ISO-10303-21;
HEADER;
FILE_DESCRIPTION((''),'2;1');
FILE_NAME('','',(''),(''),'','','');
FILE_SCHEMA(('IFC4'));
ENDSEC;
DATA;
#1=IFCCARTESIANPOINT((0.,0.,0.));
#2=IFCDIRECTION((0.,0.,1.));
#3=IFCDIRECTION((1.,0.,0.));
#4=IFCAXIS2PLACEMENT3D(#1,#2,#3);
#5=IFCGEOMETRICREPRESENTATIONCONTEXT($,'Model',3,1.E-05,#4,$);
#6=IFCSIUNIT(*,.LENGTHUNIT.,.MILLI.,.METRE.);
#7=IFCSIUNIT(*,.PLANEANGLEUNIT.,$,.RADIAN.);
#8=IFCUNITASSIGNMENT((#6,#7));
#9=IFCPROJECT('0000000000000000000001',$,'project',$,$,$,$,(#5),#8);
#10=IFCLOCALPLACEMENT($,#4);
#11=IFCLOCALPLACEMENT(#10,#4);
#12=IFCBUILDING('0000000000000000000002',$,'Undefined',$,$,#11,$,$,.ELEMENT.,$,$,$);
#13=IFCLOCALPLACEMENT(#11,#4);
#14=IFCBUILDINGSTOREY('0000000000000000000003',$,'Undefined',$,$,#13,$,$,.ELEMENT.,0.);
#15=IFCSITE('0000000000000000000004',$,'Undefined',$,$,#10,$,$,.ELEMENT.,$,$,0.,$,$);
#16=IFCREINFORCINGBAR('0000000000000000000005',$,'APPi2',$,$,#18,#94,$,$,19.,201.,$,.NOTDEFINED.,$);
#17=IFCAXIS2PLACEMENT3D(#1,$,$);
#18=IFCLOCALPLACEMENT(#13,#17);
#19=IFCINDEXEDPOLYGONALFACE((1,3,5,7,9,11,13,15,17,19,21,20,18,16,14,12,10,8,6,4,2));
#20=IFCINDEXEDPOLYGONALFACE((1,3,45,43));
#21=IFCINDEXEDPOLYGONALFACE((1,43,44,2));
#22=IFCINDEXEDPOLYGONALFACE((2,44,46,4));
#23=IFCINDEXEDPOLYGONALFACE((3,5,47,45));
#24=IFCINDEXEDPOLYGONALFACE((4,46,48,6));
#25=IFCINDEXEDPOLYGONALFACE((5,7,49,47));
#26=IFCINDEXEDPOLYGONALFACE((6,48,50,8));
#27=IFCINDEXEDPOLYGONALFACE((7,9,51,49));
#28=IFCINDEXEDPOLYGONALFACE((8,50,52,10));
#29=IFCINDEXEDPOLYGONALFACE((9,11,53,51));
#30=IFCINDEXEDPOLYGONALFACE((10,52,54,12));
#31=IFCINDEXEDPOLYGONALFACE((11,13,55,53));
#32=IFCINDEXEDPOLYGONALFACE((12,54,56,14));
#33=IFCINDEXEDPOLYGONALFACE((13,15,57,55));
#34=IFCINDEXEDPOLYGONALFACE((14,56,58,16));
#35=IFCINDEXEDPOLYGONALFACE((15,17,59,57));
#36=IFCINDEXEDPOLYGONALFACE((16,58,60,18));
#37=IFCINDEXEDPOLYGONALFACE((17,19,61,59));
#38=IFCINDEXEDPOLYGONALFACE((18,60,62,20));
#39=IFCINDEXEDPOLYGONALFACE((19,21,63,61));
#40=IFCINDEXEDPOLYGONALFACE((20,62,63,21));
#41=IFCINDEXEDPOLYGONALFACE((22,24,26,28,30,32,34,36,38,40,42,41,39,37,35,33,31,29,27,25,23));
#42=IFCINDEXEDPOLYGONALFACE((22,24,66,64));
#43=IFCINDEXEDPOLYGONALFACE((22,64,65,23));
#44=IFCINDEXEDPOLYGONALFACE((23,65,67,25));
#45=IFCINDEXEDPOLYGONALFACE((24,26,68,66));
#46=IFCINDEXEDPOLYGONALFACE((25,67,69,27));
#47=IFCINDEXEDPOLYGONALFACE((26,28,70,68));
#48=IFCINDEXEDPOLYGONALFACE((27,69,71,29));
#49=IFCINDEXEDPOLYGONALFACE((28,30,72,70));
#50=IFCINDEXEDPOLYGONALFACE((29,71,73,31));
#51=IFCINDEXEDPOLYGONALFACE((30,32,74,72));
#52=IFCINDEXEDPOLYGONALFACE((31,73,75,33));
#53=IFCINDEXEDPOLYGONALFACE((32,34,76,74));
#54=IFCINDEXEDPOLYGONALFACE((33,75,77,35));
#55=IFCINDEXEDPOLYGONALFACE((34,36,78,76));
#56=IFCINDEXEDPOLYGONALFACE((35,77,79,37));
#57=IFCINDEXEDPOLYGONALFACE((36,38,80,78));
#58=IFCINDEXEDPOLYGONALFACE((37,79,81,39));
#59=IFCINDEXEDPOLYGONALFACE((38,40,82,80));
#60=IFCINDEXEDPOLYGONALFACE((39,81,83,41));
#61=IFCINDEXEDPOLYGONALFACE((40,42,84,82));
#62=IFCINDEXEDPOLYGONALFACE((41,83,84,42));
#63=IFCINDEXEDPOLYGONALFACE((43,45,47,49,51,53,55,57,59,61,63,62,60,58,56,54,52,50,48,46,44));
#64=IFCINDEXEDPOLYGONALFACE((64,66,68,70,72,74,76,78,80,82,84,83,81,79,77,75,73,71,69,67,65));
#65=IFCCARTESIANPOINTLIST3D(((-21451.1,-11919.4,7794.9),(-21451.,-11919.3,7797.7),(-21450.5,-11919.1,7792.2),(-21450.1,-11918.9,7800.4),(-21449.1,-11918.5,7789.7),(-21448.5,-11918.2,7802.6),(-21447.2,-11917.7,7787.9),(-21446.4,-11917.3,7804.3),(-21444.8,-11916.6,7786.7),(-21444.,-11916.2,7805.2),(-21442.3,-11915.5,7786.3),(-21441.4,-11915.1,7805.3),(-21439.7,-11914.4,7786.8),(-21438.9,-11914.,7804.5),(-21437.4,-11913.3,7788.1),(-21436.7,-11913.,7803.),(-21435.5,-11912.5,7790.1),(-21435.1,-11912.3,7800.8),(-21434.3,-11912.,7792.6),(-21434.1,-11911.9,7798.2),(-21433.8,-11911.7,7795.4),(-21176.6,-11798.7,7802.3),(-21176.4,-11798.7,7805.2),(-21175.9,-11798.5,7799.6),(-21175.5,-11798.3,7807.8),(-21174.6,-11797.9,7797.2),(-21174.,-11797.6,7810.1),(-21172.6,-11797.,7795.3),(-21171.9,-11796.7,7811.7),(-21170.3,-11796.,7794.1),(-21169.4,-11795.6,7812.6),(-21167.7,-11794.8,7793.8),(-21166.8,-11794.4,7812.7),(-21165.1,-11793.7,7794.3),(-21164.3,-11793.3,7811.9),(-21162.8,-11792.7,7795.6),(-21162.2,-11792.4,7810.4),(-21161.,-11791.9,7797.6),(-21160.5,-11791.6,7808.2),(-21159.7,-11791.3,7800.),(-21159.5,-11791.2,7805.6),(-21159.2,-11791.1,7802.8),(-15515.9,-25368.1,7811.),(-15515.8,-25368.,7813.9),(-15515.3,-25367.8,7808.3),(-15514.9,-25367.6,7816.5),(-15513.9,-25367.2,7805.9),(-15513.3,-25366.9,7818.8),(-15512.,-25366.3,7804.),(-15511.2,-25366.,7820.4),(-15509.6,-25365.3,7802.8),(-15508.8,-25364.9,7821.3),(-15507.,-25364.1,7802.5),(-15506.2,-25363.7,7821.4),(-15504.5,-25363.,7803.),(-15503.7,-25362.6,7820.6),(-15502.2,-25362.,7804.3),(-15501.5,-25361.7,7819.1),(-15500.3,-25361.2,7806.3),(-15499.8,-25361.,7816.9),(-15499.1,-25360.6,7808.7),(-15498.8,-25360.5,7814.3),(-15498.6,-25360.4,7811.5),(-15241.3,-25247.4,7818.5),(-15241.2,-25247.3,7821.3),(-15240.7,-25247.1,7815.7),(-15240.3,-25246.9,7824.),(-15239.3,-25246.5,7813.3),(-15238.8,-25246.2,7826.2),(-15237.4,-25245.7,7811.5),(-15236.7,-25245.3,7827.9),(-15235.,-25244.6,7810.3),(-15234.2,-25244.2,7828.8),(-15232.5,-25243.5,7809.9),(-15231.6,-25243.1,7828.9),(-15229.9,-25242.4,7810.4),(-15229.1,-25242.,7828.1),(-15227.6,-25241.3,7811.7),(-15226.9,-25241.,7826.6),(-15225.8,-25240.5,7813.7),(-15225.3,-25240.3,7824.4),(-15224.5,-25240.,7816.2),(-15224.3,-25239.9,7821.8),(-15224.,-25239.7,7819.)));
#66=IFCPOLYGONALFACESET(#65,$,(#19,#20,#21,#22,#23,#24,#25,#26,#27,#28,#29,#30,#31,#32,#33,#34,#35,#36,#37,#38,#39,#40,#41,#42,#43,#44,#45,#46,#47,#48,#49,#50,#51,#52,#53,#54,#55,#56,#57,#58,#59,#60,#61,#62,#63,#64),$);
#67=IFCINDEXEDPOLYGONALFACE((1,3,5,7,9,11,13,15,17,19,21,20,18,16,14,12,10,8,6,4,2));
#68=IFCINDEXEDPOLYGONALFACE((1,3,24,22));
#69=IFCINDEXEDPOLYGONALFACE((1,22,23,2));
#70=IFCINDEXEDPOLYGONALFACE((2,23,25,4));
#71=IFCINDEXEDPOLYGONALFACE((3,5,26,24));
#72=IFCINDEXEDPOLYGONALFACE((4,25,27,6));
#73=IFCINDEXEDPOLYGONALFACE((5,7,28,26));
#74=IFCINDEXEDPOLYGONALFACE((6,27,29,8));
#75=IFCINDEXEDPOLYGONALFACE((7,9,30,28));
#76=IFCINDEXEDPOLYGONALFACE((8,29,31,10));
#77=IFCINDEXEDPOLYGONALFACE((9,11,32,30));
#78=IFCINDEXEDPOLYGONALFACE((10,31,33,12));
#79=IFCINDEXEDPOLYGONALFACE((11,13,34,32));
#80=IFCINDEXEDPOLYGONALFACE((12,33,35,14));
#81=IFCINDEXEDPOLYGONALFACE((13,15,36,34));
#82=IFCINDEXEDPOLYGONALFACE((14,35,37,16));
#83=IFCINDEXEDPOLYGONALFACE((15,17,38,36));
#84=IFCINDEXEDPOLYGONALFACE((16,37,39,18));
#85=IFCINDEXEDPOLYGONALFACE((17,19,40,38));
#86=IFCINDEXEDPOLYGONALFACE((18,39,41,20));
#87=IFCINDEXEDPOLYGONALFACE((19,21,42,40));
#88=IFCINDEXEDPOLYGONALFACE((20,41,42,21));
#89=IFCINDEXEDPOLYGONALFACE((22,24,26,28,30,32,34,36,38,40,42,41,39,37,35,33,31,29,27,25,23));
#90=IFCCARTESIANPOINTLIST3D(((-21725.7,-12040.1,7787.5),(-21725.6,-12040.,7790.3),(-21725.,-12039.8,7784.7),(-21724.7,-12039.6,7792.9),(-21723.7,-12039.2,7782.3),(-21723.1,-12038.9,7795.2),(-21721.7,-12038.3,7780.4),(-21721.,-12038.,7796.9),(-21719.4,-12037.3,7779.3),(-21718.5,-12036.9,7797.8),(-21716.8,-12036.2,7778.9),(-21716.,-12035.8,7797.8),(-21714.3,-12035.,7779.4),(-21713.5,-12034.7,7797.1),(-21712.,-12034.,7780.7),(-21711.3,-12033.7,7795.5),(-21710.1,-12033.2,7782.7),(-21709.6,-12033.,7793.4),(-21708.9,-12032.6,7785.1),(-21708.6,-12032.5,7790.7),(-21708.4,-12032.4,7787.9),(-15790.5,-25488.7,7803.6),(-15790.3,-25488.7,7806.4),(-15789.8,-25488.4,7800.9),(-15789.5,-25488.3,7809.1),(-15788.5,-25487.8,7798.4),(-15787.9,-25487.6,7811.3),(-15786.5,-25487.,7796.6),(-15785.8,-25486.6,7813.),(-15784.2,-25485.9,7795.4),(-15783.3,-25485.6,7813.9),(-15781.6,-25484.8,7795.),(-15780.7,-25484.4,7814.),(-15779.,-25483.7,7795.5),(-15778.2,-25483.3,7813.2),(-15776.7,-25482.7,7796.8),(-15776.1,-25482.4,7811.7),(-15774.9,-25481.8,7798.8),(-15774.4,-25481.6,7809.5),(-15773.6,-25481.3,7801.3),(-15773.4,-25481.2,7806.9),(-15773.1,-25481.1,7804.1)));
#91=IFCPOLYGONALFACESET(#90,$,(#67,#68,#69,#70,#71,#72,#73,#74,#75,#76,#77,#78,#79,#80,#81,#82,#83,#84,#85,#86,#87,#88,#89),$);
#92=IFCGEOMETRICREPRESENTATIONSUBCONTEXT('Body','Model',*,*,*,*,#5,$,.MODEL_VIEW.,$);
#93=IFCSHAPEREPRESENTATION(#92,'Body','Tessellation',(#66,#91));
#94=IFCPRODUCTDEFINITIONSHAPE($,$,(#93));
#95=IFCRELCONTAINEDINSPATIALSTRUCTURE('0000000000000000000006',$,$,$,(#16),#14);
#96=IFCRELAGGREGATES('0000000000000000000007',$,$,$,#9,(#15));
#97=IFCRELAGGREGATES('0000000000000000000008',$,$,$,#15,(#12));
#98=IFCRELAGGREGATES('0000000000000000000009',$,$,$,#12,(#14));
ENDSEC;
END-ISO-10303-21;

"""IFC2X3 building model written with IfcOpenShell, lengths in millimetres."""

from ifc_helpers import new_model, entity, si_unit, frame, origin_with_axes, place, context, subcontext, project, spatial, source, transform, mapped, element, save


model = new_model("IFC2X3")

# Units and contexts
model_context = context("Model", 3, precision=1e-05, world=origin_with_axes())
body_context = subcontext(model_context, "Body", "Model", "MODEL_VIEW")
ifc_project = project(units=[si_unit("LENGTHUNIT", "METRE", prefix="MILLI"), si_unit("PLANEANGLEUNIT", "RADIAN")], contexts=[model_context])

# Site, building, storey
site_placement = place(None, origin_with_axes())
site = spatial("IfcSite", under=ifc_project, at=site_placement, Name="Undefined", CompositionType="ELEMENT", RefElevation=0.0)
building_placement = place(site_placement, origin_with_axes())
building = spatial("IfcBuilding", under=site, at=building_placement, Name="Undefined", CompositionType="ELEMENT")
storey_placement = place(building_placement, origin_with_axes())
storey = spatial("IfcBuildingStorey", under=building, at=storey_placement, Name="Undefined", CompositionType="ELEMENT", Elevation=0.0)

# Reinforcing bar
shared_shape_1 = source(origin_with_axes(), body_context, "Body", "AdvancedSweptSolid", [
    entity("IfcSweptDiskSolid", entity("IfcTrimmedCurve", entity("IfcLine", entity("IfcCartesianPoint", [0.0, 0.0, 0.0]), entity("IfcVector", entity("IfcDirection", [1.0, 0.0, 0.0]), 1.0)), [entity("IfcParameterValue", 0.0)], [entity("IfcParameterValue", 14700.118544)], True, "PARAMETER"), 9.5, None, 0.0, 14700.1),
])
shared_shape_2 = source(origin_with_axes(), body_context, "Body", "AdvancedSweptSolid", [
    entity("IfcSweptDiskSolid", entity("IfcTrimmedCurve", entity("IfcLine", entity("IfcCartesianPoint", [0.0, 0.0, 0.0]), entity("IfcVector", entity("IfcDirection", [1.0, 0.0, 0.0]), 1.0)), [entity("IfcParameterValue", 0.0)], [entity("IfcParameterValue", 14700.118544)], True, "PARAMETER"), 9.5, None, 0.0, 14700.1),
])
shared_shape_3 = source(origin_with_axes(), body_context, "Body", "AdvancedSweptSolid", [
    entity("IfcSweptDiskSolid", entity("IfcTrimmedCurve", entity("IfcLine", entity("IfcCartesianPoint", [0.0, 0.0, 0.0]), entity("IfcVector", entity("IfcDirection", [1.0, 0.0, 0.0]), 1.0)), [entity("IfcParameterValue", 0.0)], [entity("IfcParameterValue", 14700.118544)], True, "PARAMETER"), 9.5, None, 0.0, 14700.1),
])
reinforcing_bar_1_placement = place(storey_placement, frame((-21167.9, -11794.9, 7803.3), z_axis=(0.023142, 0.009013, -0.999692), x_axis=(0.403753, -0.914867, 0.001099)))
element("IfcReinforcingBar", 1, at=reinforcing_bar_1_placement, inside=storey, Name="APPi2", BarRole="NOTDEFINED", CrossSectionArea=201.0, NominalDiameter=19.0, context=body_context, shape_type="MappedRepresentation", body=[
    mapped(shared_shape_1, transform((0.0, 0.0, 0.0))),
    mapped(shared_shape_2, transform((-0.5, 300.0, 0.0))),
    mapped(shared_shape_3, transform((-0.9, 600.0, 0.0))),
])

save(model, "model.ifc")
